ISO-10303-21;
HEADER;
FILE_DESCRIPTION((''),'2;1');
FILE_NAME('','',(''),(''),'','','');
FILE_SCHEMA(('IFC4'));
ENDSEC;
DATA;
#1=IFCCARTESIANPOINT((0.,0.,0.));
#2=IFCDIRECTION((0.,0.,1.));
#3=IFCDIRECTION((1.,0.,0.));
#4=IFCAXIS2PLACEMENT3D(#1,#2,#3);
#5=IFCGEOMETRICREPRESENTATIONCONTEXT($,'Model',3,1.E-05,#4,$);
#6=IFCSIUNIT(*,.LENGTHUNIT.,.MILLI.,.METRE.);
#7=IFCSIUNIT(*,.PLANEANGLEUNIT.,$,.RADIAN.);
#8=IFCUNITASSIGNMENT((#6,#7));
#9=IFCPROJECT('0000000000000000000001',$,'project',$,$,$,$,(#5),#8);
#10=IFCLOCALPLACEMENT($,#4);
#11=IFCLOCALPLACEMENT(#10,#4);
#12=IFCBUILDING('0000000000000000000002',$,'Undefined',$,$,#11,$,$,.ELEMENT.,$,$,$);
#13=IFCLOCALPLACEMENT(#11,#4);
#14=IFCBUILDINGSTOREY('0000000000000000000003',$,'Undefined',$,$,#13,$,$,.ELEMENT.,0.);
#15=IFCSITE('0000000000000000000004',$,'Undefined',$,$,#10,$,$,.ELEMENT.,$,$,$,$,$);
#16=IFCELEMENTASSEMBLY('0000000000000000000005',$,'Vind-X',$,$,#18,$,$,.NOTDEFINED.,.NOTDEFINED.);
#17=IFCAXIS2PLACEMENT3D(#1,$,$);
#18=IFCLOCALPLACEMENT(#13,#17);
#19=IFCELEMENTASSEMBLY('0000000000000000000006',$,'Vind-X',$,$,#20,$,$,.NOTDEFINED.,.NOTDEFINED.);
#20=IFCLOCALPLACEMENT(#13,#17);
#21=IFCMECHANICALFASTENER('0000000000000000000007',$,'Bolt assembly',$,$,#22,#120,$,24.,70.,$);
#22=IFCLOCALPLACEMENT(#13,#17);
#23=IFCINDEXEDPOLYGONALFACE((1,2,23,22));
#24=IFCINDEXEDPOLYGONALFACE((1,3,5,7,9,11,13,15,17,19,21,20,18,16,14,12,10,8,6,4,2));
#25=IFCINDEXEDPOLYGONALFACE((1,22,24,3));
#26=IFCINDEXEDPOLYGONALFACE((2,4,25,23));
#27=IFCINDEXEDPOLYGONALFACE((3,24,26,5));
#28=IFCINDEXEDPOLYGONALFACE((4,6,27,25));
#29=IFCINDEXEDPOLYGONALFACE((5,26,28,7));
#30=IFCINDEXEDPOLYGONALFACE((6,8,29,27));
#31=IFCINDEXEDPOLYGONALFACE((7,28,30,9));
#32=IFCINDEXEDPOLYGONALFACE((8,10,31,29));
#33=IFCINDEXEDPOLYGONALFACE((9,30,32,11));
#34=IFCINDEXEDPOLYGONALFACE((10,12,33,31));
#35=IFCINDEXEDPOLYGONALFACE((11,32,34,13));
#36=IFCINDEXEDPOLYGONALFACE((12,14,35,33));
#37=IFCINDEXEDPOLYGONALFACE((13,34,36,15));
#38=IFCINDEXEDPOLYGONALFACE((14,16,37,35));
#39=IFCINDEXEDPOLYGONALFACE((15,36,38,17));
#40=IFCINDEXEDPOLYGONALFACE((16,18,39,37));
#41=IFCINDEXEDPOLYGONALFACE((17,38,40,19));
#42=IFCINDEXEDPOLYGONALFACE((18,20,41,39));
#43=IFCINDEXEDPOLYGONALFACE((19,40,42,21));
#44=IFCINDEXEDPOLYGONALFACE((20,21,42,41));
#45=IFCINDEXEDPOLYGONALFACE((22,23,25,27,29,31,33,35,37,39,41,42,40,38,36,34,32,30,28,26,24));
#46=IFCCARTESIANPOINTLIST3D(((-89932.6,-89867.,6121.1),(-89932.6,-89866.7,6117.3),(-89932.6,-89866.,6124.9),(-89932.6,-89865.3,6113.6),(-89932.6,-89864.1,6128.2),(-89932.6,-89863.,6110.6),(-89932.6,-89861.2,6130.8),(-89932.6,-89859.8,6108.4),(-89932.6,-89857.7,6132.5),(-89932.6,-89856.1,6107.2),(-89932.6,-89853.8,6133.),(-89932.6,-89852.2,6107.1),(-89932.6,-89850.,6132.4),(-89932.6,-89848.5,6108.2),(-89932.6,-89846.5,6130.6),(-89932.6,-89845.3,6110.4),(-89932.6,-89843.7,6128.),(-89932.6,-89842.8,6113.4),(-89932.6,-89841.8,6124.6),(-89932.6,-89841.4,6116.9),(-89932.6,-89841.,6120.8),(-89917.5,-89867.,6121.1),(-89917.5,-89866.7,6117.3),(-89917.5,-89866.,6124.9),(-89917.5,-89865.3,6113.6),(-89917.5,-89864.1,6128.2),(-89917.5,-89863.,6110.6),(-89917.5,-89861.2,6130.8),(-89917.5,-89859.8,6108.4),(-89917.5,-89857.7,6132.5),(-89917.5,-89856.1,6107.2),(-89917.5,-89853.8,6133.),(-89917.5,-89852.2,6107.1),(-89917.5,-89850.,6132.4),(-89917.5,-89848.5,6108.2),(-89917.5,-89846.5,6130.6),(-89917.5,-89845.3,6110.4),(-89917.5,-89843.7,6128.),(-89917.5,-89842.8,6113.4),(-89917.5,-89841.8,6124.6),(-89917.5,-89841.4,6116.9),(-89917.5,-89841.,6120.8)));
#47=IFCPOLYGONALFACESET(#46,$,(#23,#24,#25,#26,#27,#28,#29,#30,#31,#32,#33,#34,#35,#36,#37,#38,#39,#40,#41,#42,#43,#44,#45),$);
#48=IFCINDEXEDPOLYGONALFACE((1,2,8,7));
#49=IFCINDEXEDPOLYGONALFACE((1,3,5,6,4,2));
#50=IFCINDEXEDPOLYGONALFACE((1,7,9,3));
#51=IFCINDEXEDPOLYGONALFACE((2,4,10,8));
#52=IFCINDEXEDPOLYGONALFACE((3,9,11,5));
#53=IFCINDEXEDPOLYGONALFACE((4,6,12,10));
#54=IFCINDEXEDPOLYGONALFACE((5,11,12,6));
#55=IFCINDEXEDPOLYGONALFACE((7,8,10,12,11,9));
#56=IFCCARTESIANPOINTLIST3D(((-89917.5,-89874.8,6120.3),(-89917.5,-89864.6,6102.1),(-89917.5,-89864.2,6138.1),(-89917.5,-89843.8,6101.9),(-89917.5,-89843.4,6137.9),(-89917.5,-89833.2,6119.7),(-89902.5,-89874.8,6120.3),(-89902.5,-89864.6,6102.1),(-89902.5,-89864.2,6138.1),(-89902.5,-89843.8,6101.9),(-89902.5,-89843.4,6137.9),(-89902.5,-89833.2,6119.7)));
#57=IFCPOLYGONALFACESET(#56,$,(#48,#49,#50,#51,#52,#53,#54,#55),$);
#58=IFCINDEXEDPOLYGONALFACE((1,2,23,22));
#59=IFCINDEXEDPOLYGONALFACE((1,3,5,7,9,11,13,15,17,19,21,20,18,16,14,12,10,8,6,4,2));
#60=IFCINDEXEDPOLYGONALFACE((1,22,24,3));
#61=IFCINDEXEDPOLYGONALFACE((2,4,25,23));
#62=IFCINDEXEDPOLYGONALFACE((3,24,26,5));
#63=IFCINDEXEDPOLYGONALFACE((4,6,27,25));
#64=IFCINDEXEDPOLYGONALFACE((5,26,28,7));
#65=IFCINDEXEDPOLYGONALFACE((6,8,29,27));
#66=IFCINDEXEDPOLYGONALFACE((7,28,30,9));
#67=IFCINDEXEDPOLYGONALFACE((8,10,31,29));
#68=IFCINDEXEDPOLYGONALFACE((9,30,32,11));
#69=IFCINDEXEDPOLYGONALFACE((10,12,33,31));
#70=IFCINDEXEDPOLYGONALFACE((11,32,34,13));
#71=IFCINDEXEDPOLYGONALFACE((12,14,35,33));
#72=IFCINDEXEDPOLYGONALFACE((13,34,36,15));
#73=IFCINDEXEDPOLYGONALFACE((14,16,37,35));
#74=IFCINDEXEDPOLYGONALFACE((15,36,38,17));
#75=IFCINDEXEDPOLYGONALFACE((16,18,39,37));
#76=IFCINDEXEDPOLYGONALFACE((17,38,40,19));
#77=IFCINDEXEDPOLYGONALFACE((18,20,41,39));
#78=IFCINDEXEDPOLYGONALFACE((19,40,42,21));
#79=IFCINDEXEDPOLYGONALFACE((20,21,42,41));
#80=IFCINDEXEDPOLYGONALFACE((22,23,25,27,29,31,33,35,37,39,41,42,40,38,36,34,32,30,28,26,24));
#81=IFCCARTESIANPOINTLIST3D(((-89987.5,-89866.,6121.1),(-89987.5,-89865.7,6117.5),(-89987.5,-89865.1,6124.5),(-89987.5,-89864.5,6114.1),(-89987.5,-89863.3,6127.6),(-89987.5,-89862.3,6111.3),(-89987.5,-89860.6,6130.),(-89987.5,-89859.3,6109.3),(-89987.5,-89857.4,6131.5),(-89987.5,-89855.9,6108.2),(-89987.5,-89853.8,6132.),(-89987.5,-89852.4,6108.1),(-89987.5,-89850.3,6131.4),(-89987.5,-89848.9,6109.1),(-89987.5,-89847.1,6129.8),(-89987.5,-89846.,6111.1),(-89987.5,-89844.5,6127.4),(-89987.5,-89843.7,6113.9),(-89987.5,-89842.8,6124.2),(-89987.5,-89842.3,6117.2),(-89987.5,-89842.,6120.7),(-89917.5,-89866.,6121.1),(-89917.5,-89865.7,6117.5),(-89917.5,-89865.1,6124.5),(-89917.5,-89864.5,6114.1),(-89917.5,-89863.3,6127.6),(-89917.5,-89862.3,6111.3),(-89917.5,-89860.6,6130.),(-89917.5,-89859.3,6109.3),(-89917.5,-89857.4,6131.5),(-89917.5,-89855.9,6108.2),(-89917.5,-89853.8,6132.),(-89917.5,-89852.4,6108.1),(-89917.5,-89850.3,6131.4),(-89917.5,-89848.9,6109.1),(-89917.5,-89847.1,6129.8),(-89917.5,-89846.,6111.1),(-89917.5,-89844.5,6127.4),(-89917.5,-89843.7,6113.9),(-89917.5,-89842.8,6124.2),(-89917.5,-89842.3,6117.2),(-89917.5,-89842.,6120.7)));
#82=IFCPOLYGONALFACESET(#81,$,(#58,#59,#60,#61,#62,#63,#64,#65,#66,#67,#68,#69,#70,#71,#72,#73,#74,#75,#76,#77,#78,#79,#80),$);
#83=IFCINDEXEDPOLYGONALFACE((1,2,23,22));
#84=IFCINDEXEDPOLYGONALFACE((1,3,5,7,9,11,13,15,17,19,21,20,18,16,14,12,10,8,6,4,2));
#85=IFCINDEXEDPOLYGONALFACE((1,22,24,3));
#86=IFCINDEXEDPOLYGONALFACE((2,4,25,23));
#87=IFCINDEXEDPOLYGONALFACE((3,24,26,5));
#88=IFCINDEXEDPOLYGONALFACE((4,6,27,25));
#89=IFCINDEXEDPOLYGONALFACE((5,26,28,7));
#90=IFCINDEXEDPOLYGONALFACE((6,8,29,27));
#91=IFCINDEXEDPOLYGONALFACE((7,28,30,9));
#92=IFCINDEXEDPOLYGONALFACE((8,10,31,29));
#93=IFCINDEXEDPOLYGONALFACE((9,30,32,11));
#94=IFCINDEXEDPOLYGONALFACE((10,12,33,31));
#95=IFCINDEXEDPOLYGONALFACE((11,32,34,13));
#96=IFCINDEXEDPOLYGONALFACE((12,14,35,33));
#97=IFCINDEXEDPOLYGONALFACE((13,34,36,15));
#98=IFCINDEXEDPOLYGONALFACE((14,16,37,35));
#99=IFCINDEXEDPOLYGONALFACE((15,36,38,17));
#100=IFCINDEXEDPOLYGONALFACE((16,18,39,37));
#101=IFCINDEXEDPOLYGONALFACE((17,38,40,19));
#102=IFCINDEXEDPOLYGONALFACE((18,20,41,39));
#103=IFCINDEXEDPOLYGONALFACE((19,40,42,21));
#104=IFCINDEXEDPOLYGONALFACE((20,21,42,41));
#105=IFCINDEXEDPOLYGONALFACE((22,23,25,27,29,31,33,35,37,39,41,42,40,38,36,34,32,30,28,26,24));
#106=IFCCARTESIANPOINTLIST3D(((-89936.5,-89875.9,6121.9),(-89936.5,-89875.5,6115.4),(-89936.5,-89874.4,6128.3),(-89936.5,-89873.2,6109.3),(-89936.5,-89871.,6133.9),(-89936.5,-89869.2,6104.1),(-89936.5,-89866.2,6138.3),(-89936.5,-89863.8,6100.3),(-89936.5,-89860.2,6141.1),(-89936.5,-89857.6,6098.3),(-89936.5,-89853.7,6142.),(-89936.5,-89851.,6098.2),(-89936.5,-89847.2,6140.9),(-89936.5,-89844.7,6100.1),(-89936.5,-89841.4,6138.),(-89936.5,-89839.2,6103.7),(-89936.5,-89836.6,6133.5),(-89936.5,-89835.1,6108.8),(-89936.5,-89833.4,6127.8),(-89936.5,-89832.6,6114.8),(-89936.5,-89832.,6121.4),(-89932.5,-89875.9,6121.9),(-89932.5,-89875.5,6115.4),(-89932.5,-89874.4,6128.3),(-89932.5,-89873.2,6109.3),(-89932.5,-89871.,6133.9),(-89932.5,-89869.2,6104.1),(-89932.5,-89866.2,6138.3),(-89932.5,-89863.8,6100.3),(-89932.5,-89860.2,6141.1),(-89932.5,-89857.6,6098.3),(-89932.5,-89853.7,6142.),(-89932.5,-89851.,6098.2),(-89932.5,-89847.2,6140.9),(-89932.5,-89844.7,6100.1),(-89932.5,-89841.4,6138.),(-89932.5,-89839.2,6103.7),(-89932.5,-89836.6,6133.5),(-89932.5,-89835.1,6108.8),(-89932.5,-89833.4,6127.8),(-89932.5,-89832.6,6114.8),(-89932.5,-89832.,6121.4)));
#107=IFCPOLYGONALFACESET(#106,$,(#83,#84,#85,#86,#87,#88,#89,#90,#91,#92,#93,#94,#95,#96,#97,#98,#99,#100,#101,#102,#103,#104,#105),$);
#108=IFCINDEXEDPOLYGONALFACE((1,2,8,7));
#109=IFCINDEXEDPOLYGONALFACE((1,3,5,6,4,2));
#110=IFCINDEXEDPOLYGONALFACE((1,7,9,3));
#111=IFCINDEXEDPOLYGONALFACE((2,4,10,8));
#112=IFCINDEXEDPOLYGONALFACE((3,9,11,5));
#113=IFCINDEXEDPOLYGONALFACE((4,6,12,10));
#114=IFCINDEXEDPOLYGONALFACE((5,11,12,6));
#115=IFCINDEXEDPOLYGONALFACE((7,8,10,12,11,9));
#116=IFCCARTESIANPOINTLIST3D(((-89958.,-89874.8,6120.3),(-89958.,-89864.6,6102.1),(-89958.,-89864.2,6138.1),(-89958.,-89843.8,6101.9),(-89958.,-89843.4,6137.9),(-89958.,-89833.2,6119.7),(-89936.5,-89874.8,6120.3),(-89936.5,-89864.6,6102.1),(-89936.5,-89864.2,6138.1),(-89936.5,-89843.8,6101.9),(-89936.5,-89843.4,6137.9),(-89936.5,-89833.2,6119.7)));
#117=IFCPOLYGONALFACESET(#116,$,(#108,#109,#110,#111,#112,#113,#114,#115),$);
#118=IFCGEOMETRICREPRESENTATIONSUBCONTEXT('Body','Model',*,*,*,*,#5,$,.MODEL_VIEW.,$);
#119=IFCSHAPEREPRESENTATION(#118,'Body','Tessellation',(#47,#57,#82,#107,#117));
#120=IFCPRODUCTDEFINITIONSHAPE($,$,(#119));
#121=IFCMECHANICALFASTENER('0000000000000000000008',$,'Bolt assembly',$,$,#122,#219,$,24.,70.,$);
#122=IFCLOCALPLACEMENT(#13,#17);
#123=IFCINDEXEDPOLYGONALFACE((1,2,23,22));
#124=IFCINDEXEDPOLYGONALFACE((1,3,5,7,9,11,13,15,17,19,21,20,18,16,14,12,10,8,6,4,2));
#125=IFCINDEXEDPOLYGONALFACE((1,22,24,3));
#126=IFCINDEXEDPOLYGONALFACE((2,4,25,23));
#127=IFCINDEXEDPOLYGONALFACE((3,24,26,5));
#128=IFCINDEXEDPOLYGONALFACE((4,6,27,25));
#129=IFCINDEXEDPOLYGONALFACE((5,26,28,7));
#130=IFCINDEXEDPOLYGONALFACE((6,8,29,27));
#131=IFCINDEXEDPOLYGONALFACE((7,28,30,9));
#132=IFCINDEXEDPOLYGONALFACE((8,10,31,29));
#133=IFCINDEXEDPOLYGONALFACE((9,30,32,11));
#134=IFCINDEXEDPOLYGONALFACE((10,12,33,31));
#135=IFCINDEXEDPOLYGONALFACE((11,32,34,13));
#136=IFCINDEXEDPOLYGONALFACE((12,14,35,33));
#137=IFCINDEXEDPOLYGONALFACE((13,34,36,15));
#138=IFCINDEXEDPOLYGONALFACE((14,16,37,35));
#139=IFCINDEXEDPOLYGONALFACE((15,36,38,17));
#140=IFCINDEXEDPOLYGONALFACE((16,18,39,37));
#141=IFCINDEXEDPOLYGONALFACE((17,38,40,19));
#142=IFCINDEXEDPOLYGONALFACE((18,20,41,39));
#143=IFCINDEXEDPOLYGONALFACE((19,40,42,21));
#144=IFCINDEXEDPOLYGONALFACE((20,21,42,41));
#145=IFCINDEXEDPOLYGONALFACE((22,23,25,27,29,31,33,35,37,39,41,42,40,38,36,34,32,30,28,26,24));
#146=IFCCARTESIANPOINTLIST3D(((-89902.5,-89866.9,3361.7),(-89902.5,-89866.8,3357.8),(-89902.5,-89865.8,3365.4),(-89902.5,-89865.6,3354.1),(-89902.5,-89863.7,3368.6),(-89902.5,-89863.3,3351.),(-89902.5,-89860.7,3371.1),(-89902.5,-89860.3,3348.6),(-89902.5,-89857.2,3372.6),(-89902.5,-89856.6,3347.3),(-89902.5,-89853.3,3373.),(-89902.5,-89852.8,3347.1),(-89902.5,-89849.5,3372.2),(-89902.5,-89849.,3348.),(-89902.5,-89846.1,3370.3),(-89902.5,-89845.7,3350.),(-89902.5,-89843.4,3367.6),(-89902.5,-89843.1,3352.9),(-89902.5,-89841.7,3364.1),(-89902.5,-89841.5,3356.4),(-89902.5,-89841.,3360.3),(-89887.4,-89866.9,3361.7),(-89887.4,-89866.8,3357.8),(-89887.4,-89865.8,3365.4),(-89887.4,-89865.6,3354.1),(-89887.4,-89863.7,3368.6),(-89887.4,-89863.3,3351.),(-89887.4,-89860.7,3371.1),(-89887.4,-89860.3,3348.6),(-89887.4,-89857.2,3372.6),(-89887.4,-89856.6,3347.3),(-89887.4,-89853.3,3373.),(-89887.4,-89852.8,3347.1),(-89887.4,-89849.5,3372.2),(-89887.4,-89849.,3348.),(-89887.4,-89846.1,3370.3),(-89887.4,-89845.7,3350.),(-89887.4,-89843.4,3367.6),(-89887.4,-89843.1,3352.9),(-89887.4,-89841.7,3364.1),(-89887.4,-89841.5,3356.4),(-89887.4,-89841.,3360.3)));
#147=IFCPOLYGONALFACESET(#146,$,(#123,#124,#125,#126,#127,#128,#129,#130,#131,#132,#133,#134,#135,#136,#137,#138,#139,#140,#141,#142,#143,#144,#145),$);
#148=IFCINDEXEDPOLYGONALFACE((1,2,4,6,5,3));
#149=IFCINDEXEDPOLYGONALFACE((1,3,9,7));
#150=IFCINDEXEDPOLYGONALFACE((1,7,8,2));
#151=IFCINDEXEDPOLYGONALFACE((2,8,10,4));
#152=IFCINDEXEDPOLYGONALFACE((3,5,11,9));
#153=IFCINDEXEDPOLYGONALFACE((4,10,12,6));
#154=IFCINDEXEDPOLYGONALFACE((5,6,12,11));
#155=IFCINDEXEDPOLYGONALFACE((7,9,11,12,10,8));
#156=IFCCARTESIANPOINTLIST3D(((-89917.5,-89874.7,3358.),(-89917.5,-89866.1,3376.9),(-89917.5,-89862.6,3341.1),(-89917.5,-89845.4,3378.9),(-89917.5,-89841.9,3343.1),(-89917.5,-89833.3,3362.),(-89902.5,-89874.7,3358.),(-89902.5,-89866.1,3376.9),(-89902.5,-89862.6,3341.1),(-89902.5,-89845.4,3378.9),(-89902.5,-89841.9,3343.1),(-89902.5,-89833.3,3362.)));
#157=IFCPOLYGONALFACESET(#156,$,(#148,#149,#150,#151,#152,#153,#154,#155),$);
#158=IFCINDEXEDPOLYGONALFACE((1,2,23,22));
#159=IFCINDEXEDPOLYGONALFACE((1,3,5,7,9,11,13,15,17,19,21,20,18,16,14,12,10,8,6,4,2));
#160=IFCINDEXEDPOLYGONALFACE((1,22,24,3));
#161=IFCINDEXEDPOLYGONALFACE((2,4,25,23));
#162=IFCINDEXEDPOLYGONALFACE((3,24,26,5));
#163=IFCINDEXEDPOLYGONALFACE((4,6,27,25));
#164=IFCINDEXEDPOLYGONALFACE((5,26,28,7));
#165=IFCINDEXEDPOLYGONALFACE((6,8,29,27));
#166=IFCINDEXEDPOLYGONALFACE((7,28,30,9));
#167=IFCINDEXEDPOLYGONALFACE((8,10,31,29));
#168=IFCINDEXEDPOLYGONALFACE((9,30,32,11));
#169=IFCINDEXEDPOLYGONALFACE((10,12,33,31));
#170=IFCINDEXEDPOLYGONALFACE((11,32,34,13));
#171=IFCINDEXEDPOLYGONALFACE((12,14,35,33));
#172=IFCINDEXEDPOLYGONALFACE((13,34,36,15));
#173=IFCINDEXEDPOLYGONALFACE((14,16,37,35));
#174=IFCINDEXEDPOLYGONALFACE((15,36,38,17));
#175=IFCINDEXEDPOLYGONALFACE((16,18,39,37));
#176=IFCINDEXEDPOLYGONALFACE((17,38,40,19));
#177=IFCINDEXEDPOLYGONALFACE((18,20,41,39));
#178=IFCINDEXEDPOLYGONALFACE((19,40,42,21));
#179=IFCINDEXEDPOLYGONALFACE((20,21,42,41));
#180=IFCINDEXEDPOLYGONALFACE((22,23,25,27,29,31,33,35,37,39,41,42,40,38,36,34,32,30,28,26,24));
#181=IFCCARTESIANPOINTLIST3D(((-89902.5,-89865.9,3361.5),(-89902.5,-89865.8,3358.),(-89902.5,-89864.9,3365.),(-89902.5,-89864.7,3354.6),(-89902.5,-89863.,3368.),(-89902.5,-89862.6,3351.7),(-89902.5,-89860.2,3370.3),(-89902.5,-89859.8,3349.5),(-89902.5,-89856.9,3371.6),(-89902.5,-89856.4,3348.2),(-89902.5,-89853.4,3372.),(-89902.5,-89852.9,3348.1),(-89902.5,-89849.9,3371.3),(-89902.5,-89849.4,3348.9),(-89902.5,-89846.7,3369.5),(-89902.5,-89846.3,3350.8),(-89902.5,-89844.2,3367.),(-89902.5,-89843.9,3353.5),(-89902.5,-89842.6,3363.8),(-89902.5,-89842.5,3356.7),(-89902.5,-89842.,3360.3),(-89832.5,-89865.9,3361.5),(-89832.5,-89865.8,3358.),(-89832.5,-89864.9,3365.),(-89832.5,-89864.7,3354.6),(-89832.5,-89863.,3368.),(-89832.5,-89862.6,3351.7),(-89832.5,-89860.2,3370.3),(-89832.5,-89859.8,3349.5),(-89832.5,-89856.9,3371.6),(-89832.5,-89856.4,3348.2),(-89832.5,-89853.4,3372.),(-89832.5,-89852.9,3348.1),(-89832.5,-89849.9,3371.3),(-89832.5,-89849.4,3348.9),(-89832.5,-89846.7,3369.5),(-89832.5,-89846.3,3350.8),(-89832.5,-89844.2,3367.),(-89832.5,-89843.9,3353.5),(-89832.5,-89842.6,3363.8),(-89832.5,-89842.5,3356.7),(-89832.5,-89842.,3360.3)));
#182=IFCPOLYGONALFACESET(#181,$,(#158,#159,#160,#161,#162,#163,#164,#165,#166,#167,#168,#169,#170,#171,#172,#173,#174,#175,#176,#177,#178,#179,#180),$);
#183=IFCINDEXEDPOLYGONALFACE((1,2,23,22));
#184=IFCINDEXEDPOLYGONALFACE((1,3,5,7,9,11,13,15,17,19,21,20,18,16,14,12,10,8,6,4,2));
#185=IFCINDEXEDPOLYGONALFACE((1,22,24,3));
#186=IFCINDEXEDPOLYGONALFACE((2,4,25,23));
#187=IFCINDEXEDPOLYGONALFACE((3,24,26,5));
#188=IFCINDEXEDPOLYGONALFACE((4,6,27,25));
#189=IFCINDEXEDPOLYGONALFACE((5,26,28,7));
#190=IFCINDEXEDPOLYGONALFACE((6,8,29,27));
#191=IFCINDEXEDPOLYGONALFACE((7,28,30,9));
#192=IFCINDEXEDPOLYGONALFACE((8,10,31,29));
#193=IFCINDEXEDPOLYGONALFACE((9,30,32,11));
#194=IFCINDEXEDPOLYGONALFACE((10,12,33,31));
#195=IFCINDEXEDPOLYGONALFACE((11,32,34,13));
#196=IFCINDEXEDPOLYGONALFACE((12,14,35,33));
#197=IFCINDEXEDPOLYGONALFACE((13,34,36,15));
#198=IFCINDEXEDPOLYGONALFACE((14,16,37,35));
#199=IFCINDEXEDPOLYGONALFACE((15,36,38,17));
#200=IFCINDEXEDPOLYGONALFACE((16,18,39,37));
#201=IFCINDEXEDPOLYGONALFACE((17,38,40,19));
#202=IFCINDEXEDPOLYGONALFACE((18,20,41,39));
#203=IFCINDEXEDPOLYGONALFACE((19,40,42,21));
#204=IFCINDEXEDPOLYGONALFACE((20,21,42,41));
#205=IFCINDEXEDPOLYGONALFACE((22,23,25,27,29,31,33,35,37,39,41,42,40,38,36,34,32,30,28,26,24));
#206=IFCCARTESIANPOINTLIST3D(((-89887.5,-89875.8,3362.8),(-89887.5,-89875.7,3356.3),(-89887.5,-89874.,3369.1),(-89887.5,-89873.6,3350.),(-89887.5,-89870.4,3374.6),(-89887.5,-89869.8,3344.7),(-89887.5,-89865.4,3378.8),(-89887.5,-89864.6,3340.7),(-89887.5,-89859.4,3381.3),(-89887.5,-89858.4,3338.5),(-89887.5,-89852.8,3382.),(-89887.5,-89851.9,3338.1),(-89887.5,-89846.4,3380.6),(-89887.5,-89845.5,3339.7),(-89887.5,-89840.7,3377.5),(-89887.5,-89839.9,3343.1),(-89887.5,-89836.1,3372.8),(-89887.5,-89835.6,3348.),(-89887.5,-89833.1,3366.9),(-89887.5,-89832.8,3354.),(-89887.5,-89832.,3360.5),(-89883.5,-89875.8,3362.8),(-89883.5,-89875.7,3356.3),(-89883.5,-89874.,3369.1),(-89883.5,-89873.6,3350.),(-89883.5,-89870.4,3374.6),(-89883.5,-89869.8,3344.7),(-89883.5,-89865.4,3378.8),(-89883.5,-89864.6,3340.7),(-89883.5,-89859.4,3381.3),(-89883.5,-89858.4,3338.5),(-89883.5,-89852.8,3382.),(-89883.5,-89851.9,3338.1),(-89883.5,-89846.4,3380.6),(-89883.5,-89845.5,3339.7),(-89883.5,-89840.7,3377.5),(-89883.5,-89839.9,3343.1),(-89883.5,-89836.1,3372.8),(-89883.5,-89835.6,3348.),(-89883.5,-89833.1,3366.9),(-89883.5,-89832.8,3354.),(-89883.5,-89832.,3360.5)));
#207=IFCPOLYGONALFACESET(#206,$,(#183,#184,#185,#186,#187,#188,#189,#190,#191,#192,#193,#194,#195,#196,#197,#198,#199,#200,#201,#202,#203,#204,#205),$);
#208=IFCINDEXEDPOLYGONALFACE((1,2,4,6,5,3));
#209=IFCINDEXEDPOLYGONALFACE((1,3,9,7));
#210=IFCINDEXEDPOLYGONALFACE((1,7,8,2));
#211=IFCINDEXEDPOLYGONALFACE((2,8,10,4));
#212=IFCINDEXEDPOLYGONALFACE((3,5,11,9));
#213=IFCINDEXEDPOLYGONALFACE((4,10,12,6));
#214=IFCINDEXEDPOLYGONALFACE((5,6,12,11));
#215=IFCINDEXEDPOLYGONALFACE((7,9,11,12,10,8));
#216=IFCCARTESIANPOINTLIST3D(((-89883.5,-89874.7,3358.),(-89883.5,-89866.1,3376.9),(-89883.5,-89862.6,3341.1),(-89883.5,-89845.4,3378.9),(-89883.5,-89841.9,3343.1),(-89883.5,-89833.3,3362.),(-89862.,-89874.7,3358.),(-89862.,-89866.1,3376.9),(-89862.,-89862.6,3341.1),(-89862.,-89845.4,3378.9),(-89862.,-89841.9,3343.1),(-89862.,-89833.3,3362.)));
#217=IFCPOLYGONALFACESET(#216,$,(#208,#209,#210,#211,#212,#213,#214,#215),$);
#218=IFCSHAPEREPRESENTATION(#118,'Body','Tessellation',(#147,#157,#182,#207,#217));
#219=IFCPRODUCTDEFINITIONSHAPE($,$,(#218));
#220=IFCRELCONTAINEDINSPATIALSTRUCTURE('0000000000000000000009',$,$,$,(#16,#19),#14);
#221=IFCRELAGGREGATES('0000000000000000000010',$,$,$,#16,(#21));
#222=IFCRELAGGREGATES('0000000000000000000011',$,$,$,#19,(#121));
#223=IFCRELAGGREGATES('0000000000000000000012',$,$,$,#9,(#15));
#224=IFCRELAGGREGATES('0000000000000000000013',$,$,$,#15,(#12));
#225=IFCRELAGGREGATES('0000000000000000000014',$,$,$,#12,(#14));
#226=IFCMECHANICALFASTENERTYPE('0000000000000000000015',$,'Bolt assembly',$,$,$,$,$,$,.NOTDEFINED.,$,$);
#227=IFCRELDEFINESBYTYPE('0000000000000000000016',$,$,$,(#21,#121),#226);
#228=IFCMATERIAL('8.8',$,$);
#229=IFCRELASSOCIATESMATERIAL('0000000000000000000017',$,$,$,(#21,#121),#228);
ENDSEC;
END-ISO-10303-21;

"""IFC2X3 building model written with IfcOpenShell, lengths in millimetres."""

from ifc_helpers import new_model, si_unit, frame, origin_with_axes, origin_2d_with_axis, place, context, subcontext, project, spatial, polyline, circle, outline, extrude, source, transform, mapped, material, type_object, element, aggregate, save


model = new_model("IFC2X3")

# Units and contexts
model_context = context("Model", 3, precision=1e-05, world=origin_with_axes())
body_context = subcontext(model_context, "Body", "Model", "MODEL_VIEW")
ifc_project = project(units=[si_unit("LENGTHUNIT", "METRE", prefix="MILLI"), si_unit("PLANEANGLEUNIT", "RADIAN")], contexts=[model_context])

# Site, building, storey
site_placement = place(None, origin_with_axes())
site = spatial("IfcSite", under=ifc_project, at=site_placement, Name="Undefined", CompositionType="ELEMENT")
building_placement = place(site_placement, origin_with_axes())
building = spatial("IfcBuilding", under=site, at=building_placement, Name="Undefined", CompositionType="ELEMENT")
storey_placement = place(building_placement, origin_with_axes())
storey = spatial("IfcBuildingStorey", under=building, at=storey_placement, Name="Undefined", CompositionType="ELEMENT", Elevation=0.0)

# Element assemblies
assembly_1_placement = place(storey_placement, origin_with_axes())
assembly_1 = element("IfcElementAssembly", 1, at=assembly_1_placement, inside=storey, Name="Vind-X", AssemblyPlace="NOTDEFINED", PredefinedType="NOTDEFINED")
assembly_2_placement = place(storey_placement, origin_with_axes())
assembly_2 = element("IfcElementAssembly", 2, at=assembly_2_placement, inside=storey, Name="Vind-X", AssemblyPlace="NOTDEFINED", PredefinedType="NOTDEFINED")

# Mechanical fasteners
ifc_material_1 = material(Name="8.8")
mechanical_fastener_type = type_object("IfcMechanicalFastenerType", Name="Bolt assembly")
shared_shape_1 = source(origin_with_axes(), body_context, "Body", "SweptSolid", [
    extrude(circle(Radius=13.0, at=origin_2d_with_axis()), frame((0.0, 0.0, 0.0), z_axis=(0.0, 1.0, 0.0), x_axis=(1.0, 0.0, 0.0)), (0.0, 0.0, 1.0), 15.1),
    extrude(outline(polyline([(18.0, -10.4), (18.0, 10.4), (0.0, 20.8), (-18.0, 10.4), (-18.0, -10.4), (0.0, -20.8), (18.0, -10.4)])), frame((0.0, -15.0, 0.0), z_axis=(0.0, 1.0, 0.0), x_axis=(1.0, 0.0, 0.0)), (0.0, 0.0, 1.0), 15.0),
    extrude(circle(Radius=12.0, at=origin_2d_with_axis()), frame((0.0, 0.0, 0.0), z_axis=(0.0, 1.0, 0.0), x_axis=(1.0, 0.0, 0.0)), (0.0, 0.0, 1.0), 70.0),
    extrude(circle(Radius=22.0, at=origin_2d_with_axis()), frame((0.0, 15.0, 0.0), z_axis=(0.0, 1.0, 0.0), x_axis=(1.0, 0.0, 0.0)), (0.0, 0.0, 1.0), 4.0),
    extrude(outline(polyline([(18.0, -10.4), (18.0, 10.4), (0.0, 20.8), (-18.0, 10.4), (-18.0, -10.4), (0.0, -20.8), (18.0, -10.4)])), frame((0.0, 19.0, 0.0), z_axis=(0.0, 1.0, 0.0), x_axis=(1.0, 0.0, 0.0)), (0.0, 0.0, 1.0), 21.5),
])
mechanical_fastener_1_placement = place(assembly_1_placement, frame((-89917.5, -89854.0, 6120.0), z_axis=(0.0, 0.511223, 0.859448), x_axis=(0.0, 0.859448, -0.511223)))
mechanical_fastener_1 = element("IfcMechanicalFastener", 3, at=mechanical_fastener_1_placement, type_object=mechanical_fastener_type, material=ifc_material_1, Name="Bolt assembly", NominalDiameter=24.0, NominalLength=70.0, context=body_context, shape_type="MappedRepresentation", body=[
    mapped(shared_shape_1, transform((0.0, 0.0, 0.0))),
])
aggregate(assembly_1, [mechanical_fastener_1])
mechanical_fastener_2_placement = place(assembly_2_placement, frame((-89902.5, -89854.0, 3360.0), z_axis=(0.0, 0.58074, -0.814089), x_axis=(0.0, 0.814089, 0.58074)))
mechanical_fastener_2 = element("IfcMechanicalFastener", 4, at=mechanical_fastener_2_placement, type_object=mechanical_fastener_type, material=ifc_material_1, Name="Bolt assembly", NominalDiameter=24.0, NominalLength=70.0, context=body_context, shape_type="MappedRepresentation", body=[
    mapped(shared_shape_1, transform((0.0, 0.0, 0.0))),
])
aggregate(assembly_2, [mechanical_fastener_2])

save(model, "model.ifc")
